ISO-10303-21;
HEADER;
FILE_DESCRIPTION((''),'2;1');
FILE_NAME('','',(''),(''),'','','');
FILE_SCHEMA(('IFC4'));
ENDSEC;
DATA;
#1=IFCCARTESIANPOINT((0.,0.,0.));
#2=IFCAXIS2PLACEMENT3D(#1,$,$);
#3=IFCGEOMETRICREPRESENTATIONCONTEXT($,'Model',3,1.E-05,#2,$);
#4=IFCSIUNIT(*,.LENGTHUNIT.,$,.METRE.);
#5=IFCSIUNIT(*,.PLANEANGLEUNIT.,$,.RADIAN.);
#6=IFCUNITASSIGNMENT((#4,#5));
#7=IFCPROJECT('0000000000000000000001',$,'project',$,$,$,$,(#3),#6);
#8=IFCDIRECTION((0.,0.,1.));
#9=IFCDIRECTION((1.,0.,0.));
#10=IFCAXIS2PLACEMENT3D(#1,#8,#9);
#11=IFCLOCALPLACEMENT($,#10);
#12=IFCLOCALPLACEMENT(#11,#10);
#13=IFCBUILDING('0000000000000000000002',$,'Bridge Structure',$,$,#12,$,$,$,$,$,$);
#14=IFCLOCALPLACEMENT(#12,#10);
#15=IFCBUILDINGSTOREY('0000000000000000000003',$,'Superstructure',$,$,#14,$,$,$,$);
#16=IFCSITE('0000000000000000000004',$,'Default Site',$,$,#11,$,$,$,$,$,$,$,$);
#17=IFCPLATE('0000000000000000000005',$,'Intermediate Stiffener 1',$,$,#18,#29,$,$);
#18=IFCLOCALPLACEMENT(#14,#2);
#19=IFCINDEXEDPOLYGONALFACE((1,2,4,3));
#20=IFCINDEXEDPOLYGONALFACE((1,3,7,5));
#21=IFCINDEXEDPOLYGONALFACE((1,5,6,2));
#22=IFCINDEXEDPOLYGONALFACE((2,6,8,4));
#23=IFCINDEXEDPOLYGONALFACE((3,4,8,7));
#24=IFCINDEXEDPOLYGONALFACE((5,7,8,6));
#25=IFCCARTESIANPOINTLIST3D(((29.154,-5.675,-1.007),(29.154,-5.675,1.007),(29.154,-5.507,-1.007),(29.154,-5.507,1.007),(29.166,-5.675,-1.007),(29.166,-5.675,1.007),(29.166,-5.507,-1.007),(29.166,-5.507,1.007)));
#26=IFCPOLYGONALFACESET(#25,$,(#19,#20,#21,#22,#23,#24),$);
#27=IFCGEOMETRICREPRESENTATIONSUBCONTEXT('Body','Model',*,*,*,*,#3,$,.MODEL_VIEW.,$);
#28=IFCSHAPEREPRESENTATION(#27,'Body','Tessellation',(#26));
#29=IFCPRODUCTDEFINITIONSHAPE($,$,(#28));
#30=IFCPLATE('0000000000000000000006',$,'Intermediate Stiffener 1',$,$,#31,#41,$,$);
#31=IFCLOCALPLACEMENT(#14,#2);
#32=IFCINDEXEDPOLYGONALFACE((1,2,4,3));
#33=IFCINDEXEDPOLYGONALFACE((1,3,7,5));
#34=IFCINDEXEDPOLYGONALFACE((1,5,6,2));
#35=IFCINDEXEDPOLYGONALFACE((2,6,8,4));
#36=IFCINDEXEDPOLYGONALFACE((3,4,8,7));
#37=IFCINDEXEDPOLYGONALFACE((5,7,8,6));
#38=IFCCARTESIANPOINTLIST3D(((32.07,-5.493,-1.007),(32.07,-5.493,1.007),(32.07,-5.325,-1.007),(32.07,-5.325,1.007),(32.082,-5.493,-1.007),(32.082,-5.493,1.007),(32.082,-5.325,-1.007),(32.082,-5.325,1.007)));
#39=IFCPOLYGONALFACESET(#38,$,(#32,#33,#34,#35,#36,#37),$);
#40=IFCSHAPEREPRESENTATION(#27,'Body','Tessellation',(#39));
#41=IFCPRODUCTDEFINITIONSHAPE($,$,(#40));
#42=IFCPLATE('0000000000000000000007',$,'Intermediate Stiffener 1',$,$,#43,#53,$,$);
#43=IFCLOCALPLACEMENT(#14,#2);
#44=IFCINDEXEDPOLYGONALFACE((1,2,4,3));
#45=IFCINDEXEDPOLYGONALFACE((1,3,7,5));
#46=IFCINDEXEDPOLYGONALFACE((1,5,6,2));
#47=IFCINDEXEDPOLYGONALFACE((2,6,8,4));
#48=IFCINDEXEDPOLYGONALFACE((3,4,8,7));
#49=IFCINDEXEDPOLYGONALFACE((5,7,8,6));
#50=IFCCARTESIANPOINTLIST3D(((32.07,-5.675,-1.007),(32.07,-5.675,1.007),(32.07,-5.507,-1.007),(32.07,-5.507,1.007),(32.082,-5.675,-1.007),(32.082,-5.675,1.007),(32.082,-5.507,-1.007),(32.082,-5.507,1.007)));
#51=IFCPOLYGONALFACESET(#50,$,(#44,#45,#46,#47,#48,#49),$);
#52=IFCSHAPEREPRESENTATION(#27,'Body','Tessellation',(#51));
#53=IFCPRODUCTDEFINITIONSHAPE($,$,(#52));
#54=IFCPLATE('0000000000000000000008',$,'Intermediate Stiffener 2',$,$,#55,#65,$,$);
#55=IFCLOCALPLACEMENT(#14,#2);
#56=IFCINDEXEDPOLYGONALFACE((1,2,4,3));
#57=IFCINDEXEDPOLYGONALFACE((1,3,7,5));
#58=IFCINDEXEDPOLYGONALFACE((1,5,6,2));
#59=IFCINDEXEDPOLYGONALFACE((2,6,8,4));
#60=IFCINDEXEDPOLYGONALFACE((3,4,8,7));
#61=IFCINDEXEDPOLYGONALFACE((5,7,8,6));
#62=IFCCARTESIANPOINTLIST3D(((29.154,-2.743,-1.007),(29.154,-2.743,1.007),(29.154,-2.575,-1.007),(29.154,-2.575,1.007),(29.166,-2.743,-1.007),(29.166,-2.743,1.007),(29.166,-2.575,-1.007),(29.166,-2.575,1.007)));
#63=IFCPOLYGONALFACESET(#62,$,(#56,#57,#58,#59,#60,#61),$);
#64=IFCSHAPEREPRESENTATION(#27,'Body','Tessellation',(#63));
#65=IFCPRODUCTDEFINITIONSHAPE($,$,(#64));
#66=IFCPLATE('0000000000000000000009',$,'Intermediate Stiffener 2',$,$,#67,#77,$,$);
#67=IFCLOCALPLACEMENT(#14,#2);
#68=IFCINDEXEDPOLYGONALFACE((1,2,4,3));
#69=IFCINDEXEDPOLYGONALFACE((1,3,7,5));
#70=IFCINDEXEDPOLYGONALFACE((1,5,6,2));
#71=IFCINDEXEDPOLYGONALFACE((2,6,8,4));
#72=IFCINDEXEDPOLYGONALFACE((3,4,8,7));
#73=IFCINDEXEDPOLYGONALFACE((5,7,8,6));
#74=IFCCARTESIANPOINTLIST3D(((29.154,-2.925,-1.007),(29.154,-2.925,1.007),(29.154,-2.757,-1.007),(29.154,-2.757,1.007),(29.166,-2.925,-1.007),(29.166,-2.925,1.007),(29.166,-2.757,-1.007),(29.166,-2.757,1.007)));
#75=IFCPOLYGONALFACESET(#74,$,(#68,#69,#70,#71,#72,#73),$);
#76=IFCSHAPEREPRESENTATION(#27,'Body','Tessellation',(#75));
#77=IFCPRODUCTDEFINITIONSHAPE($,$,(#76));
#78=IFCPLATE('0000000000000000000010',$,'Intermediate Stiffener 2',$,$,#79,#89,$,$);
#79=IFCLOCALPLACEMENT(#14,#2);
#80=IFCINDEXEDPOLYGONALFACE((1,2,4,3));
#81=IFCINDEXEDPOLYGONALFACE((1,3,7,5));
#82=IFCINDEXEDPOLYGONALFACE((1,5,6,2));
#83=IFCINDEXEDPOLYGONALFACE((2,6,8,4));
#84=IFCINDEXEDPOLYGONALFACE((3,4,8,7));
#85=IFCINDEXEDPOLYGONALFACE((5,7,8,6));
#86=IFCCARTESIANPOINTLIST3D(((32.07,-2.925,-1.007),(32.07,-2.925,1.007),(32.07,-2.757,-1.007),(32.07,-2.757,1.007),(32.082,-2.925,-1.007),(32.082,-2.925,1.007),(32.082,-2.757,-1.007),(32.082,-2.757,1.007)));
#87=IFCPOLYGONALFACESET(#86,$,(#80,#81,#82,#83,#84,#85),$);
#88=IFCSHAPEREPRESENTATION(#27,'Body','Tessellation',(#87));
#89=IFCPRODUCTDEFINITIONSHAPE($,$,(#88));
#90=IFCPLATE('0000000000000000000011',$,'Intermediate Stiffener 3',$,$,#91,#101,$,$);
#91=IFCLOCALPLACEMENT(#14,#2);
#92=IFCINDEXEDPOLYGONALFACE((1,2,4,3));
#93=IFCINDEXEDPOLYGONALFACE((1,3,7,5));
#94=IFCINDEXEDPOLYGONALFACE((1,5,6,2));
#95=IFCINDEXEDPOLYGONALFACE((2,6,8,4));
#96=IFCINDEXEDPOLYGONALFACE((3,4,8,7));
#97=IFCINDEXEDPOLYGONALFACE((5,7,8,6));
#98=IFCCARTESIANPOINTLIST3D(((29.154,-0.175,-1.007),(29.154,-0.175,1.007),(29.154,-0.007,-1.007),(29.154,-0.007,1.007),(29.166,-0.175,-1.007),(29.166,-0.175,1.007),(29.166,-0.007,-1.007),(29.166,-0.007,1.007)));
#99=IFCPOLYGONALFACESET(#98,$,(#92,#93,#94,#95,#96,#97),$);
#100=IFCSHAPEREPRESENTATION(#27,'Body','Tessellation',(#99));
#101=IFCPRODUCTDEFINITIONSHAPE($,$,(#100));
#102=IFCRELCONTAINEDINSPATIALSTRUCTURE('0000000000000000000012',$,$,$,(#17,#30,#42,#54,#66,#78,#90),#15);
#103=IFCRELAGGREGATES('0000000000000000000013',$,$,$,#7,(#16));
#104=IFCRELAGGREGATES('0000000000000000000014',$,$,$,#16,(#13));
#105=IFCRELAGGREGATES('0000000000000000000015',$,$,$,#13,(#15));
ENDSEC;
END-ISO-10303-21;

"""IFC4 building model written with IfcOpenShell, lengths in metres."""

from ifc_helpers import new_model, si_unit, frame, origin, origin_with_axes, origin_2d_with_axis, place, context, subcontext, project, spatial, rectangle, extrude, element, save


model = new_model("IFC4")

# Units and contexts
model_context = context("Model", 3, precision=1e-05, world=origin())
body_context = subcontext(model_context, "Body", "Model", "MODEL_VIEW")
ifc_project = project(units=[si_unit("LENGTHUNIT", "METRE"), si_unit("PLANEANGLEUNIT", "RADIAN")], contexts=[model_context])

# Site, building, storey
site_placement = place(None, origin_with_axes())
site = spatial("IfcSite", under=ifc_project, at=site_placement, Name="Default Site")
building_placement = place(site_placement, origin_with_axes())
building = spatial("IfcBuilding", under=site, at=building_placement, Name="Bridge Structure")
storey_placement = place(building_placement, origin_with_axes())
storey = spatial("IfcBuildingStorey", under=building, at=storey_placement, Name="Superstructure")

# Plates
for number, where, z_axis, x_axis, name in (
    (1, (29.16, -5.591, -1.007), (0.0, 0.0, 1.0), (1.0, 0.0, 0.0), "Intermediate Stiffener 1"),
    (2, (32.076, -5.409, -1.007), (0.0, 0.0, 1.0), (1.0, 0.0, 0.0), "Intermediate Stiffener 1"),
    (3, (32.076, -5.591, -1.007), (0.0, 0.0, 1.0), (1.0, 0.0, 0.0), "Intermediate Stiffener 1"),
    (4, (29.16, -2.659, -1.007), (0.0, 0.0, 1.0), (1.0, 0.0, 0.0), "Intermediate Stiffener 2"),
    (5, (29.16, -2.841, -1.007), (0.0, 0.0, 1.0), (1.0, 0.0, 0.0), "Intermediate Stiffener 2"),
    (6, (32.076, -2.841, -1.007), (0.0, 0.0, 1.0), (1.0, 0.0, 0.0), "Intermediate Stiffener 2"),
    (7, (29.16, -0.091, -1.007), (0.0, 0.0, 1.0), (1.0, 0.0, 0.0), "Intermediate Stiffener 3"),
):
    element("IfcPlate", number, at=place(storey_placement, frame(where, z_axis=z_axis, x_axis=x_axis)), inside=storey, Name=name, context=body_context, shape_type="SweptSolid", body=[
        extrude(rectangle(XDim=0.012, YDim=0.168, at=origin_2d_with_axis()), origin_with_axes(), (0.0, 0.0, 1.0), 2.014),
    ])

save(model, "model.ifc")
